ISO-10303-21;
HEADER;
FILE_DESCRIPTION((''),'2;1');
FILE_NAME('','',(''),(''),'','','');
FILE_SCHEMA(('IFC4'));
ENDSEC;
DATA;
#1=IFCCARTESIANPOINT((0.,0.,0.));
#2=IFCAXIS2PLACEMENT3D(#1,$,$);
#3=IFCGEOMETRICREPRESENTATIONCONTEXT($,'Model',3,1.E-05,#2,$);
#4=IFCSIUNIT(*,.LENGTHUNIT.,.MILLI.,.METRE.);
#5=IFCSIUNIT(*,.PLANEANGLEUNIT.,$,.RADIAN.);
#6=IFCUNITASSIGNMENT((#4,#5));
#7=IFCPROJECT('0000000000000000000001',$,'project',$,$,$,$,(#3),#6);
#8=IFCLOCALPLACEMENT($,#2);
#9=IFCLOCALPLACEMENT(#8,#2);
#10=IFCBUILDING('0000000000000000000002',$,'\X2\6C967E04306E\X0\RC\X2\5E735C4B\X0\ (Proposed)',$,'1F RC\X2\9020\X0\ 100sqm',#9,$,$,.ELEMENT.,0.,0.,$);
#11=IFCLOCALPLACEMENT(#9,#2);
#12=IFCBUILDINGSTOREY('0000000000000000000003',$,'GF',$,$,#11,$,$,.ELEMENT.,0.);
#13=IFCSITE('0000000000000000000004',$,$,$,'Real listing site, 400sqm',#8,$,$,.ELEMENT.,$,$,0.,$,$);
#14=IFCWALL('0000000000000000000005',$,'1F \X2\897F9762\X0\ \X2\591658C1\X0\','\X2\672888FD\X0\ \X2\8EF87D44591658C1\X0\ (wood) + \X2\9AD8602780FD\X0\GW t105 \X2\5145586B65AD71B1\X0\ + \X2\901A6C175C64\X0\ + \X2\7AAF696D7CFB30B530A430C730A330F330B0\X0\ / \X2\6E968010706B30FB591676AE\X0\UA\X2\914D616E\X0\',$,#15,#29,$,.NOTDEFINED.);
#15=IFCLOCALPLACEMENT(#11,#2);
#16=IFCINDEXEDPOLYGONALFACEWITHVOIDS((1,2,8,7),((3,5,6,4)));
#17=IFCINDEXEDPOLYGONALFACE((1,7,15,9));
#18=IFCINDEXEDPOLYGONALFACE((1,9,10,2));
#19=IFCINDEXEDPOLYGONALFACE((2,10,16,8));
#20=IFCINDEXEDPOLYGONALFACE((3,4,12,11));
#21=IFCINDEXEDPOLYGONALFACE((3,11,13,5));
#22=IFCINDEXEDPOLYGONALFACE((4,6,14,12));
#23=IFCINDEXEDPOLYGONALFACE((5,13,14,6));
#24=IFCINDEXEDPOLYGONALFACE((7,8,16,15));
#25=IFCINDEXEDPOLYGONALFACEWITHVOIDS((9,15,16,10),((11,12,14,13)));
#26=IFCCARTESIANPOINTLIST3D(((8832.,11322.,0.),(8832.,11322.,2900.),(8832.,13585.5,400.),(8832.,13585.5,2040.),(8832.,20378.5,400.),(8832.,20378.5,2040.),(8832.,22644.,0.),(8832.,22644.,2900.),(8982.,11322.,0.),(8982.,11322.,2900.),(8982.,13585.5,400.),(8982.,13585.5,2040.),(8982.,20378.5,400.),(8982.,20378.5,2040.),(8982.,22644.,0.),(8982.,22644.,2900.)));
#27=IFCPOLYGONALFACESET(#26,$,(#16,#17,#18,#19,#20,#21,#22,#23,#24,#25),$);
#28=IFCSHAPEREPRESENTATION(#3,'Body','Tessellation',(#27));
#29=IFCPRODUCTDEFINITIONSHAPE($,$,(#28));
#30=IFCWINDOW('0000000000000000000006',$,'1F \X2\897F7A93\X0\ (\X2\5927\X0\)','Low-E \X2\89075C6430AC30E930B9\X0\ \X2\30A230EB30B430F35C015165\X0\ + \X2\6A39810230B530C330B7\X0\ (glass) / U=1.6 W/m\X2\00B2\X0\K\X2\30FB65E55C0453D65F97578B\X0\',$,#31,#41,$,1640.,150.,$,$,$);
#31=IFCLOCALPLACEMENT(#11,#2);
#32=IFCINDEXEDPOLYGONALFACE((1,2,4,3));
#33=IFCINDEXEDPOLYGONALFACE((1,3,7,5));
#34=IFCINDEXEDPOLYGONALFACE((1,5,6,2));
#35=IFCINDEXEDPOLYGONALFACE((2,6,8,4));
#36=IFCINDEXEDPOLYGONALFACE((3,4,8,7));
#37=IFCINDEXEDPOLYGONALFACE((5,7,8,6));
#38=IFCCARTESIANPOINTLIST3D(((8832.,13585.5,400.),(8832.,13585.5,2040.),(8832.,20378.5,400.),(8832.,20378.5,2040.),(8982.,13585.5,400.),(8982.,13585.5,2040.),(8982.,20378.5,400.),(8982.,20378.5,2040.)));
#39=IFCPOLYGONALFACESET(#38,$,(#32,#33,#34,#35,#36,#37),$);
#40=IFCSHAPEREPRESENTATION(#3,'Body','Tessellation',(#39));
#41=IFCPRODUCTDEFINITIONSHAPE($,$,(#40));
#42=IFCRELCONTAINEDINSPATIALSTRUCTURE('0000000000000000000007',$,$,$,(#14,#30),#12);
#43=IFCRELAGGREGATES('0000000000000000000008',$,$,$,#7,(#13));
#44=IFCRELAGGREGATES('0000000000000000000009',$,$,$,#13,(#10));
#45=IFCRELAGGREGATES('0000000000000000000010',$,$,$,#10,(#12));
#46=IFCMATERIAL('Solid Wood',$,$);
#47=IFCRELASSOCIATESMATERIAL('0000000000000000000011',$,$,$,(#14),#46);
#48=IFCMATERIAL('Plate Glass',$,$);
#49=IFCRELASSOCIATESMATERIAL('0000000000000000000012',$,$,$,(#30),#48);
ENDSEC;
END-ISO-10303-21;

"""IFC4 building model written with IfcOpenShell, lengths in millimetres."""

from ifc_helpers import new_model, si_unit, frame, frame_2d, origin, place, context, project, spatial, rectangle, extrude, material, element, fill, save


model = new_model("IFC4")

# Units and contexts
model_context = context("Model", 3, precision=1e-05, world=origin())
ifc_project = project(units=[si_unit("LENGTHUNIT", "METRE", prefix="MILLI"), si_unit("PLANEANGLEUNIT", "RADIAN")], contexts=[model_context])

# Site, building, storey
site_placement = place(None, origin())
site = spatial("IfcSite", under=ifc_project, at=site_placement, ObjectType="Real listing site, 400sqm", CompositionType="ELEMENT", RefElevation=0.0)
building_placement = place(site_placement, origin())
building = spatial("IfcBuilding", under=site, at=building_placement, Name="沖縄のRC平屋 (Proposed)", ObjectType="1F RC造 100sqm", CompositionType="ELEMENT", ElevationOfRefHeight=0.0, ElevationOfTerrain=0.0)
storey_placement = place(building_placement, origin())
storey = spatial("IfcBuildingStorey", under=building, at=storey_placement, Name="GF", CompositionType="ELEMENT", Elevation=0.0)

# Shared definitions
ifc_material_1 = material(Name="Solid Wood")

# Shared definitions
ifc_material_2 = material(Name="Plate Glass")

# Wall, opening, window
wall_1_placement = place(storey_placement, frame((4416.0, 5661.0, 0.0)))
wall_1 = element("IfcWall", 1, at=wall_1_placement, inside=storey, material=ifc_material_1, Name="1F 西面 外壁", Description="木製 軸組外壁 (wood) + 高性能GW t105 充填断熱 + 通気層 + 窯業系サイディング / 準耐火・外皮UA配慮", PredefinedType="NOTDEFINED", context=model_context, shape_type="SweptSolid", body=[
    extrude(rectangle(XDim=150.0, YDim=11322.0, at=frame_2d((75.0, 5661.0))), frame((4416.0, 5661.0, 0.0)), (0.0, 0.0, 1.0), 2900.0),
])
opening_1_placement = place(storey_placement, frame((4416.0, 6793.0, 200.0)))
opening_1 = element("IfcOpeningElement", 2, at=opening_1_placement, cuts=wall_1, PredefinedType="NOTDEFINED", context=model_context, shape_type="SweptSolid", body=[
    extrude(rectangle(XDim=150.0, YDim=6793.0, at=frame_2d((75.0, 3396.0))), frame((4416.0, 6793.0, 200.0)), (0.0, 0.0, 1.0), 1640.0),
])
window_1_placement = place(storey_placement, frame((4416.0, 6793.0, 200.0)))
window_1 = element("IfcWindow", 3, at=window_1_placement, inside=storey, material=ifc_material_2, Name="1F 西窓 (大)", Description="Low-E 複層ガラス アルゴン封入 + 樹脂サッシ (glass) / U=1.6 W/m²K・日射取得型", OverallHeight=1640.0, OverallWidth=150.0, context=model_context, shape_type="SweptSolid", body=[
    extrude(rectangle(XDim=150.0, YDim=6793.0, at=frame_2d((75.0, 3396.0))), frame((4416.0, 6793.0, 200.0)), (0.0, 0.0, 1.0), 1640.0),
])
fill(opening_1, window_1)

save(model, "model.ifc")
